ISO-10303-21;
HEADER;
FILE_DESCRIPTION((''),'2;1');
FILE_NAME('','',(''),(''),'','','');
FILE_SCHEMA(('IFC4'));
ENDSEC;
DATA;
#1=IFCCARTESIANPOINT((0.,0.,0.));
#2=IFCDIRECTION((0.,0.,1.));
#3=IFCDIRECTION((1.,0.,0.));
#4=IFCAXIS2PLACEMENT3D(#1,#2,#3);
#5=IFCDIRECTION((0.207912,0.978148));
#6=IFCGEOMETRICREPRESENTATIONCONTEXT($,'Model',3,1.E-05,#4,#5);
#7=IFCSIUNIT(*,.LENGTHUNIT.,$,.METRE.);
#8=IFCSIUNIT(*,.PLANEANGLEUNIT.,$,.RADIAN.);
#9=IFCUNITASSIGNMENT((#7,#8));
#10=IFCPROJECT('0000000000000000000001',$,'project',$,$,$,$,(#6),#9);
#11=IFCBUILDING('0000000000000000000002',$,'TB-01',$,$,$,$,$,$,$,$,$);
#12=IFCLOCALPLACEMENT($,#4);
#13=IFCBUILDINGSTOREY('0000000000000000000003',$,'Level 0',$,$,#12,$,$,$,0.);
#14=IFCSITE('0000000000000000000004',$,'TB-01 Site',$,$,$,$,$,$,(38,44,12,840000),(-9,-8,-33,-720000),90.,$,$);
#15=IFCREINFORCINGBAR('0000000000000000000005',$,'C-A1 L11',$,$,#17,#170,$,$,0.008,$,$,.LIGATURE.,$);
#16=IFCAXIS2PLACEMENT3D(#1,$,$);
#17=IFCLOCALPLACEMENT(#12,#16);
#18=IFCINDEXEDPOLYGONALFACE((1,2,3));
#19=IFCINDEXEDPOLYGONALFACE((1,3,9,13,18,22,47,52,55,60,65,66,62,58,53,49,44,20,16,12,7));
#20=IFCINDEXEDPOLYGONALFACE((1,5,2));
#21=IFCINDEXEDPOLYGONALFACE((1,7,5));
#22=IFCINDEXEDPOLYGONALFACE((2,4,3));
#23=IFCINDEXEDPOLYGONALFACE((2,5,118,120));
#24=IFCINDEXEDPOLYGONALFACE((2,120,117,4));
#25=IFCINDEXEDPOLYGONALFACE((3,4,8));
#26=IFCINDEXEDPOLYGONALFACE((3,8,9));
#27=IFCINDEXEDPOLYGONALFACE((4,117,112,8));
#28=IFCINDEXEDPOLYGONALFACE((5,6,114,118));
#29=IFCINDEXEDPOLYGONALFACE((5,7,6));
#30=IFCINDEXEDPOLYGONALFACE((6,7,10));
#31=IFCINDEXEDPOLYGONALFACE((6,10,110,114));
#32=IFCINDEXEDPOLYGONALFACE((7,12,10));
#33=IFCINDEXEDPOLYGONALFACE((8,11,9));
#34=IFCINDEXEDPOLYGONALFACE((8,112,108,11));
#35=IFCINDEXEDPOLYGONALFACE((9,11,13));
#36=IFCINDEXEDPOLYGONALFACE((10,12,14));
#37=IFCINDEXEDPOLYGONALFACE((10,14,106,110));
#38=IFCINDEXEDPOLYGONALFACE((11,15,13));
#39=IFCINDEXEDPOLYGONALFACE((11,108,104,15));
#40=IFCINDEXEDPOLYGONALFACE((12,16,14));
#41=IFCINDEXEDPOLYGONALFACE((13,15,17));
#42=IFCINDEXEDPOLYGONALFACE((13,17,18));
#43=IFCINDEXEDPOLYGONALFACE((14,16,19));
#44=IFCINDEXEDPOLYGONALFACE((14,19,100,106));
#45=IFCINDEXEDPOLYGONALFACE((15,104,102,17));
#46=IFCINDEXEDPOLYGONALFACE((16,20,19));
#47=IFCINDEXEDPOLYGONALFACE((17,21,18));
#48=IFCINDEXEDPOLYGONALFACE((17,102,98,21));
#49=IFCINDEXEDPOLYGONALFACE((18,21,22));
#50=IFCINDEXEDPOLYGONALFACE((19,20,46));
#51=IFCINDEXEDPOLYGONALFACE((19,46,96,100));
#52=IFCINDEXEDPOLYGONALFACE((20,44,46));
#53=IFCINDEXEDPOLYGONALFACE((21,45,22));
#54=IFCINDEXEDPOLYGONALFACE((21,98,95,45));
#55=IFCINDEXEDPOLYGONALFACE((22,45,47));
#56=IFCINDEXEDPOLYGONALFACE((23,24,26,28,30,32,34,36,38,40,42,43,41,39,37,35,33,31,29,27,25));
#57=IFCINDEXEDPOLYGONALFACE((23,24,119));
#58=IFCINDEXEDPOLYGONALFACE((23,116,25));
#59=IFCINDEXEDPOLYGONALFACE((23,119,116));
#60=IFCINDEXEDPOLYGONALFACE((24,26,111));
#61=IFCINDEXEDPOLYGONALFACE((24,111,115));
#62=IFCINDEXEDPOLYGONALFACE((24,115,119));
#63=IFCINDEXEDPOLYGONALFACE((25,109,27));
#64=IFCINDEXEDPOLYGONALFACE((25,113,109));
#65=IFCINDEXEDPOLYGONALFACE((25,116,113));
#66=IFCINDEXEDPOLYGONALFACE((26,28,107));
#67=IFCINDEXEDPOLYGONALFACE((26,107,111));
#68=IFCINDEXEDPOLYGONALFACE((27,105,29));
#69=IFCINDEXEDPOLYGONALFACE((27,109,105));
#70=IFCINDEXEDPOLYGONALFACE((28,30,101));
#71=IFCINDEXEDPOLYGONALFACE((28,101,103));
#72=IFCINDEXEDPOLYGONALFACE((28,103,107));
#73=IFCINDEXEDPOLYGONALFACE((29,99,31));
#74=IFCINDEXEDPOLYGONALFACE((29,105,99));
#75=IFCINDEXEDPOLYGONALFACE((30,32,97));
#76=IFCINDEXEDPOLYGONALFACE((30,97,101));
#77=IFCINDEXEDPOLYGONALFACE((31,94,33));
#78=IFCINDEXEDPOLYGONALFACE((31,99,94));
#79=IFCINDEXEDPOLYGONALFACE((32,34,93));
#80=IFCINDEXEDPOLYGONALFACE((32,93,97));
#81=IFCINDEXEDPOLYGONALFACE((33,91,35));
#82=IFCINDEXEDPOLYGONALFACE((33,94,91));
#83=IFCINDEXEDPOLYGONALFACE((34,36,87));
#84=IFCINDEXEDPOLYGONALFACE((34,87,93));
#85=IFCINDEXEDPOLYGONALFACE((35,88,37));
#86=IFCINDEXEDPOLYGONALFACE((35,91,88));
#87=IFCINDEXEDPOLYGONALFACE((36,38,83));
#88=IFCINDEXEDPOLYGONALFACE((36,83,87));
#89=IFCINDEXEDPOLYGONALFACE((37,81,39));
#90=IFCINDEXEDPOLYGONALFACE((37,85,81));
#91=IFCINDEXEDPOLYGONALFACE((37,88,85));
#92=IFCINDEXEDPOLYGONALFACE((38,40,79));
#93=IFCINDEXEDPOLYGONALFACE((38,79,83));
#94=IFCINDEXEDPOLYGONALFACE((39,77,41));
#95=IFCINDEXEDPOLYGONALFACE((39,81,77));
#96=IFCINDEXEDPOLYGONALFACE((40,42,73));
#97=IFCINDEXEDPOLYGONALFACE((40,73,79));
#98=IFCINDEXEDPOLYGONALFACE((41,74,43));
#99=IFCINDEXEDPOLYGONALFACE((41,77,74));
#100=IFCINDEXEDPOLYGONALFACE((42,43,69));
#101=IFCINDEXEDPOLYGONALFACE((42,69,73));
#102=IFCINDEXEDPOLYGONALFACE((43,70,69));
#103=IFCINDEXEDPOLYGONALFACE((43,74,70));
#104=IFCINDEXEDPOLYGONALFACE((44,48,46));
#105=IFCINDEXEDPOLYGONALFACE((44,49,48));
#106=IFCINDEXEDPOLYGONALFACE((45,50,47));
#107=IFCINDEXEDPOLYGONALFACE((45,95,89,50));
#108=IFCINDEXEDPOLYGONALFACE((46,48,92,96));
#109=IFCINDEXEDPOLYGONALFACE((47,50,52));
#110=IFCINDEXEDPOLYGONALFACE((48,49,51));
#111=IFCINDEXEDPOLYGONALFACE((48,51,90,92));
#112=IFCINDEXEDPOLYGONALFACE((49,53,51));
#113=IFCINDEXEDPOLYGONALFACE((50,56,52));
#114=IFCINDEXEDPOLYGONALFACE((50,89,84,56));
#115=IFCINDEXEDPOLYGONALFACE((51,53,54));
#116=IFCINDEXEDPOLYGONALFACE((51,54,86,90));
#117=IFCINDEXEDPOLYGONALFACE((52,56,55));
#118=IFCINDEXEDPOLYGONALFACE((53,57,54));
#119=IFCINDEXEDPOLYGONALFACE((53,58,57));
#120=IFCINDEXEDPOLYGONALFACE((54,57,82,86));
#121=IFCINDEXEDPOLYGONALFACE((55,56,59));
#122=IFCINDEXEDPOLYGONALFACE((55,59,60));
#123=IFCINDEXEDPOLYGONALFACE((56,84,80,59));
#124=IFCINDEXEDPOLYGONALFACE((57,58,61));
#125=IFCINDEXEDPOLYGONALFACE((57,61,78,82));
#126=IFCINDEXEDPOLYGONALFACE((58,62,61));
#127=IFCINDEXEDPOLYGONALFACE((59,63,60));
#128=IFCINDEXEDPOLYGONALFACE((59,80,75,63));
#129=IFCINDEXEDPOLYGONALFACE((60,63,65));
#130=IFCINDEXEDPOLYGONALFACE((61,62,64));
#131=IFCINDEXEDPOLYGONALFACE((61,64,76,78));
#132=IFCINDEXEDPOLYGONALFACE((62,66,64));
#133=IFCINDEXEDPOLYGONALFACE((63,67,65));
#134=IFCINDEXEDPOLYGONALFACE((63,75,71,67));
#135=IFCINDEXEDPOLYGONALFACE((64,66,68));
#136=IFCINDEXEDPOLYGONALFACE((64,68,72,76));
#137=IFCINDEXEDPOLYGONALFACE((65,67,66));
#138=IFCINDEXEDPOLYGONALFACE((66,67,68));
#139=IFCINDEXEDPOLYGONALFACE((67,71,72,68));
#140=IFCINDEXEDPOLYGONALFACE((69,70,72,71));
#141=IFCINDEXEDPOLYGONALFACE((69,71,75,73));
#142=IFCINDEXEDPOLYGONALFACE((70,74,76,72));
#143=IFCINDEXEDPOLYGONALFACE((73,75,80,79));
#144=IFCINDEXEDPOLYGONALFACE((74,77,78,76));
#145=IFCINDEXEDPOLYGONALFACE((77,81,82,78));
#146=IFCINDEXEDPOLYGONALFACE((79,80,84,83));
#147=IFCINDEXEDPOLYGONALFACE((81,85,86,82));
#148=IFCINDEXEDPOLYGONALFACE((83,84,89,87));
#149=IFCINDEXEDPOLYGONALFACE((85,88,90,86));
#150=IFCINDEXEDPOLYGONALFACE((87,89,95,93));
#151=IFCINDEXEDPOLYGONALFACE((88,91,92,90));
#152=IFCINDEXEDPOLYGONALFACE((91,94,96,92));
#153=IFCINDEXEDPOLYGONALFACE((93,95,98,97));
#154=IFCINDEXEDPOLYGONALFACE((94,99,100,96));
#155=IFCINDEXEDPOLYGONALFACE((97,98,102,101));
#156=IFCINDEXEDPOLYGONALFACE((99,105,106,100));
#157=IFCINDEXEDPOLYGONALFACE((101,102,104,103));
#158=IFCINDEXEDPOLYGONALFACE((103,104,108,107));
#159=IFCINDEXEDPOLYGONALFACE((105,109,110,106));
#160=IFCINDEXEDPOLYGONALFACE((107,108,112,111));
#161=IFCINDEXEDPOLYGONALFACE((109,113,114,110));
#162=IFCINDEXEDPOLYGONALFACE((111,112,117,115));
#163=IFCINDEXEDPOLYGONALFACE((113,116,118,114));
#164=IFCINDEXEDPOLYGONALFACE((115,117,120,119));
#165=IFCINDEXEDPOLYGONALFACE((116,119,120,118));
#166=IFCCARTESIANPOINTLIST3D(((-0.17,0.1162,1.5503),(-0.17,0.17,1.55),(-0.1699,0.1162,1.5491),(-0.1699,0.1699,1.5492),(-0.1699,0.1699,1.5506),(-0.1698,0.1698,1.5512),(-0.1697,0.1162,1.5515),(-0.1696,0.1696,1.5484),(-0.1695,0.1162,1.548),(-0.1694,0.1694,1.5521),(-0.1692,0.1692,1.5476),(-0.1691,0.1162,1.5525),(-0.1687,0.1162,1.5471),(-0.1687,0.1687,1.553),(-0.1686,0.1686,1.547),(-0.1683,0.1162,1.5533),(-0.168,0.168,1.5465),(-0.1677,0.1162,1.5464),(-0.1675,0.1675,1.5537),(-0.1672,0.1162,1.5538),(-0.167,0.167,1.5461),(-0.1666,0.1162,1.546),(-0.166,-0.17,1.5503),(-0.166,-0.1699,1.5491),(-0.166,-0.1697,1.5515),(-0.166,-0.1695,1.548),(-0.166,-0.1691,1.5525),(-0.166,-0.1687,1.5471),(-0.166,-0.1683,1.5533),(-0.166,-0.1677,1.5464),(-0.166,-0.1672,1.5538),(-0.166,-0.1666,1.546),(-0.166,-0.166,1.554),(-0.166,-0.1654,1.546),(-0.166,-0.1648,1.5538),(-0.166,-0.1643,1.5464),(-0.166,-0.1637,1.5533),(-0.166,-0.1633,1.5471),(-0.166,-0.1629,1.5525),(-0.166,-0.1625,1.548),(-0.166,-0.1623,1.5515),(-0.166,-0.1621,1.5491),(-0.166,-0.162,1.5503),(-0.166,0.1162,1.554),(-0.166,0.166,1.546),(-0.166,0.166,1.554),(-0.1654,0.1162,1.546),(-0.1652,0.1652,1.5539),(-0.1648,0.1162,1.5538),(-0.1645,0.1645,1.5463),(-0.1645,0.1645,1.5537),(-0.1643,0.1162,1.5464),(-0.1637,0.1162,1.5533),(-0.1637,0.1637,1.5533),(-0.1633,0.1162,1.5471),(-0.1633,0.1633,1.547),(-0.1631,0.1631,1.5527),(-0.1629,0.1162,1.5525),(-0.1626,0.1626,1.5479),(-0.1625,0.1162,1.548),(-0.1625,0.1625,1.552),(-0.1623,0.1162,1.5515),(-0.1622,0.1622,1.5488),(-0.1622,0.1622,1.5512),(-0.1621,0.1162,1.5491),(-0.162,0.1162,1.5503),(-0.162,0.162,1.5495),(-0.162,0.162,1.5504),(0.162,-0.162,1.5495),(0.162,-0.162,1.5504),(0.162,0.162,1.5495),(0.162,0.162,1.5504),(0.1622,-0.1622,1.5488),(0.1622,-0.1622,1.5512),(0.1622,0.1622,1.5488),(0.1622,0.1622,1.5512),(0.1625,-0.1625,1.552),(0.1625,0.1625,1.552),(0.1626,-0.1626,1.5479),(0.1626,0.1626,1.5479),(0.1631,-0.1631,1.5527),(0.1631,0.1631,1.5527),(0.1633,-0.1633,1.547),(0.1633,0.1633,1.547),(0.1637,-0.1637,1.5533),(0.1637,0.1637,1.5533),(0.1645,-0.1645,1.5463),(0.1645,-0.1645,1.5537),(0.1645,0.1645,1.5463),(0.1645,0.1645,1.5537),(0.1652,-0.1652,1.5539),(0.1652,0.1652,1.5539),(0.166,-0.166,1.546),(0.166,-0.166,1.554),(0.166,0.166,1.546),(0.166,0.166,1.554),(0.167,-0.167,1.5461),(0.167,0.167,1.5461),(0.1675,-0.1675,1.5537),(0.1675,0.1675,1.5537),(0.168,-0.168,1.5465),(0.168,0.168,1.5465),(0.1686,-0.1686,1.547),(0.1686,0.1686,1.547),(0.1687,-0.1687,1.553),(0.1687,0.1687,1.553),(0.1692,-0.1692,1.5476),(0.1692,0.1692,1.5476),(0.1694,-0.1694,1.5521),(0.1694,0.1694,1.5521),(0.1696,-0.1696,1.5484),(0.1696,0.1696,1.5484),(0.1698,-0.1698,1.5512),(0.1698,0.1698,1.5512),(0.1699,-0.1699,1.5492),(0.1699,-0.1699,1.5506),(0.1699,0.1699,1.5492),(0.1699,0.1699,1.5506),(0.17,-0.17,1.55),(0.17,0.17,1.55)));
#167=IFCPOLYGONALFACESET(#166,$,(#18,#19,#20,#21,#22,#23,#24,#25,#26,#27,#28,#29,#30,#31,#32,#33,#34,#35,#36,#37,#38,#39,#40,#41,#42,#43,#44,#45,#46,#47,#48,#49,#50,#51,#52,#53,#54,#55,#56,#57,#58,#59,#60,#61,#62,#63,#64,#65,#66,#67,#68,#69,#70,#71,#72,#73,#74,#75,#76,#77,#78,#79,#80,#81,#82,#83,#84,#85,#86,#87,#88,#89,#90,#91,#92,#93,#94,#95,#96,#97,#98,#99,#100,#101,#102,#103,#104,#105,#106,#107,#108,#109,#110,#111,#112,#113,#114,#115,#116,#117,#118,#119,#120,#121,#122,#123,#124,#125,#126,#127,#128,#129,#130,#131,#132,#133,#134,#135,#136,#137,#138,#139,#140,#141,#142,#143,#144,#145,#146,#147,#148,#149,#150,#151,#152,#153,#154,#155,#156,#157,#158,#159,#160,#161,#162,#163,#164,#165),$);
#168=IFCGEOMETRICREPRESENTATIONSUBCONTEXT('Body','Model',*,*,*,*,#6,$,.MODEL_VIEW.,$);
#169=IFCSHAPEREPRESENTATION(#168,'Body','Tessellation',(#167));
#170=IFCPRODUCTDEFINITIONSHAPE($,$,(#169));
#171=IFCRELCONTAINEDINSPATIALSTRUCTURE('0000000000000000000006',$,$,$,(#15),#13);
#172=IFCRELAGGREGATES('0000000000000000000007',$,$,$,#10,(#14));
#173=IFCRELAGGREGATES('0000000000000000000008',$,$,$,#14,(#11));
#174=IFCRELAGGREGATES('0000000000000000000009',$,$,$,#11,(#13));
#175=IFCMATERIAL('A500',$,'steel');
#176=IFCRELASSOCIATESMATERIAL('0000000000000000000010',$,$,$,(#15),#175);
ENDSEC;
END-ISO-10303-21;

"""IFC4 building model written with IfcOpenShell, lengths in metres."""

from ifc_helpers import new_model, entity, si_unit, direction, origin_with_axes, place, context, subcontext, project, spatial, material, element, save


model = new_model("IFC4")

# Units and contexts
model_context = context("Model", 3, precision=1e-05, world=origin_with_axes(), true_north=direction((0.207912, 0.978148)))
body_context = subcontext(model_context, "Body", "Model", "MODEL_VIEW")
ifc_project = project(units=[si_unit("LENGTHUNIT", "METRE"), si_unit("PLANEANGLEUNIT", "RADIAN")], contexts=[model_context])

# Site, building, storey
site = spatial("IfcSite", under=ifc_project, Name="TB-01 Site", RefLatitude=(38, 44, 12, 840000), RefLongitude=(-9, -8, -33, -720000), RefElevation=90.0)
building = spatial("IfcBuilding", under=site, Name="TB-01")
storey_placement = place(None, origin_with_axes())
storey = spatial("IfcBuildingStorey", under=building, at=storey_placement, Name="Level 0", Elevation=0.0)

# Reinforcing bar
ifc_material_1 = material(Name="A500", Category="steel")
reinforcing_bar_1_placement = place(storey_placement, origin_with_axes())
element("IfcReinforcingBar", 1, at=reinforcing_bar_1_placement, inside=storey, material=ifc_material_1, Name="C-A1 L11", NominalDiameter=0.008, PredefinedType="LIGATURE", context=body_context, shape_type="AdvancedSweptSolid", body=[
    entity("IfcSweptDiskSolid", entity("IfcPolyline", [entity("IfcCartesianPoint", [-0.166, -0.166, 1.55]), entity("IfcCartesianPoint", [0.166, -0.166, 1.55]), entity("IfcCartesianPoint", [0.166, 0.166, 1.55]), entity("IfcCartesianPoint", [-0.166, 0.166, 1.55]), entity("IfcCartesianPoint", [-0.166, 0.1162, 1.55])]), 0.004),
])

save(model, "model.ifc")
